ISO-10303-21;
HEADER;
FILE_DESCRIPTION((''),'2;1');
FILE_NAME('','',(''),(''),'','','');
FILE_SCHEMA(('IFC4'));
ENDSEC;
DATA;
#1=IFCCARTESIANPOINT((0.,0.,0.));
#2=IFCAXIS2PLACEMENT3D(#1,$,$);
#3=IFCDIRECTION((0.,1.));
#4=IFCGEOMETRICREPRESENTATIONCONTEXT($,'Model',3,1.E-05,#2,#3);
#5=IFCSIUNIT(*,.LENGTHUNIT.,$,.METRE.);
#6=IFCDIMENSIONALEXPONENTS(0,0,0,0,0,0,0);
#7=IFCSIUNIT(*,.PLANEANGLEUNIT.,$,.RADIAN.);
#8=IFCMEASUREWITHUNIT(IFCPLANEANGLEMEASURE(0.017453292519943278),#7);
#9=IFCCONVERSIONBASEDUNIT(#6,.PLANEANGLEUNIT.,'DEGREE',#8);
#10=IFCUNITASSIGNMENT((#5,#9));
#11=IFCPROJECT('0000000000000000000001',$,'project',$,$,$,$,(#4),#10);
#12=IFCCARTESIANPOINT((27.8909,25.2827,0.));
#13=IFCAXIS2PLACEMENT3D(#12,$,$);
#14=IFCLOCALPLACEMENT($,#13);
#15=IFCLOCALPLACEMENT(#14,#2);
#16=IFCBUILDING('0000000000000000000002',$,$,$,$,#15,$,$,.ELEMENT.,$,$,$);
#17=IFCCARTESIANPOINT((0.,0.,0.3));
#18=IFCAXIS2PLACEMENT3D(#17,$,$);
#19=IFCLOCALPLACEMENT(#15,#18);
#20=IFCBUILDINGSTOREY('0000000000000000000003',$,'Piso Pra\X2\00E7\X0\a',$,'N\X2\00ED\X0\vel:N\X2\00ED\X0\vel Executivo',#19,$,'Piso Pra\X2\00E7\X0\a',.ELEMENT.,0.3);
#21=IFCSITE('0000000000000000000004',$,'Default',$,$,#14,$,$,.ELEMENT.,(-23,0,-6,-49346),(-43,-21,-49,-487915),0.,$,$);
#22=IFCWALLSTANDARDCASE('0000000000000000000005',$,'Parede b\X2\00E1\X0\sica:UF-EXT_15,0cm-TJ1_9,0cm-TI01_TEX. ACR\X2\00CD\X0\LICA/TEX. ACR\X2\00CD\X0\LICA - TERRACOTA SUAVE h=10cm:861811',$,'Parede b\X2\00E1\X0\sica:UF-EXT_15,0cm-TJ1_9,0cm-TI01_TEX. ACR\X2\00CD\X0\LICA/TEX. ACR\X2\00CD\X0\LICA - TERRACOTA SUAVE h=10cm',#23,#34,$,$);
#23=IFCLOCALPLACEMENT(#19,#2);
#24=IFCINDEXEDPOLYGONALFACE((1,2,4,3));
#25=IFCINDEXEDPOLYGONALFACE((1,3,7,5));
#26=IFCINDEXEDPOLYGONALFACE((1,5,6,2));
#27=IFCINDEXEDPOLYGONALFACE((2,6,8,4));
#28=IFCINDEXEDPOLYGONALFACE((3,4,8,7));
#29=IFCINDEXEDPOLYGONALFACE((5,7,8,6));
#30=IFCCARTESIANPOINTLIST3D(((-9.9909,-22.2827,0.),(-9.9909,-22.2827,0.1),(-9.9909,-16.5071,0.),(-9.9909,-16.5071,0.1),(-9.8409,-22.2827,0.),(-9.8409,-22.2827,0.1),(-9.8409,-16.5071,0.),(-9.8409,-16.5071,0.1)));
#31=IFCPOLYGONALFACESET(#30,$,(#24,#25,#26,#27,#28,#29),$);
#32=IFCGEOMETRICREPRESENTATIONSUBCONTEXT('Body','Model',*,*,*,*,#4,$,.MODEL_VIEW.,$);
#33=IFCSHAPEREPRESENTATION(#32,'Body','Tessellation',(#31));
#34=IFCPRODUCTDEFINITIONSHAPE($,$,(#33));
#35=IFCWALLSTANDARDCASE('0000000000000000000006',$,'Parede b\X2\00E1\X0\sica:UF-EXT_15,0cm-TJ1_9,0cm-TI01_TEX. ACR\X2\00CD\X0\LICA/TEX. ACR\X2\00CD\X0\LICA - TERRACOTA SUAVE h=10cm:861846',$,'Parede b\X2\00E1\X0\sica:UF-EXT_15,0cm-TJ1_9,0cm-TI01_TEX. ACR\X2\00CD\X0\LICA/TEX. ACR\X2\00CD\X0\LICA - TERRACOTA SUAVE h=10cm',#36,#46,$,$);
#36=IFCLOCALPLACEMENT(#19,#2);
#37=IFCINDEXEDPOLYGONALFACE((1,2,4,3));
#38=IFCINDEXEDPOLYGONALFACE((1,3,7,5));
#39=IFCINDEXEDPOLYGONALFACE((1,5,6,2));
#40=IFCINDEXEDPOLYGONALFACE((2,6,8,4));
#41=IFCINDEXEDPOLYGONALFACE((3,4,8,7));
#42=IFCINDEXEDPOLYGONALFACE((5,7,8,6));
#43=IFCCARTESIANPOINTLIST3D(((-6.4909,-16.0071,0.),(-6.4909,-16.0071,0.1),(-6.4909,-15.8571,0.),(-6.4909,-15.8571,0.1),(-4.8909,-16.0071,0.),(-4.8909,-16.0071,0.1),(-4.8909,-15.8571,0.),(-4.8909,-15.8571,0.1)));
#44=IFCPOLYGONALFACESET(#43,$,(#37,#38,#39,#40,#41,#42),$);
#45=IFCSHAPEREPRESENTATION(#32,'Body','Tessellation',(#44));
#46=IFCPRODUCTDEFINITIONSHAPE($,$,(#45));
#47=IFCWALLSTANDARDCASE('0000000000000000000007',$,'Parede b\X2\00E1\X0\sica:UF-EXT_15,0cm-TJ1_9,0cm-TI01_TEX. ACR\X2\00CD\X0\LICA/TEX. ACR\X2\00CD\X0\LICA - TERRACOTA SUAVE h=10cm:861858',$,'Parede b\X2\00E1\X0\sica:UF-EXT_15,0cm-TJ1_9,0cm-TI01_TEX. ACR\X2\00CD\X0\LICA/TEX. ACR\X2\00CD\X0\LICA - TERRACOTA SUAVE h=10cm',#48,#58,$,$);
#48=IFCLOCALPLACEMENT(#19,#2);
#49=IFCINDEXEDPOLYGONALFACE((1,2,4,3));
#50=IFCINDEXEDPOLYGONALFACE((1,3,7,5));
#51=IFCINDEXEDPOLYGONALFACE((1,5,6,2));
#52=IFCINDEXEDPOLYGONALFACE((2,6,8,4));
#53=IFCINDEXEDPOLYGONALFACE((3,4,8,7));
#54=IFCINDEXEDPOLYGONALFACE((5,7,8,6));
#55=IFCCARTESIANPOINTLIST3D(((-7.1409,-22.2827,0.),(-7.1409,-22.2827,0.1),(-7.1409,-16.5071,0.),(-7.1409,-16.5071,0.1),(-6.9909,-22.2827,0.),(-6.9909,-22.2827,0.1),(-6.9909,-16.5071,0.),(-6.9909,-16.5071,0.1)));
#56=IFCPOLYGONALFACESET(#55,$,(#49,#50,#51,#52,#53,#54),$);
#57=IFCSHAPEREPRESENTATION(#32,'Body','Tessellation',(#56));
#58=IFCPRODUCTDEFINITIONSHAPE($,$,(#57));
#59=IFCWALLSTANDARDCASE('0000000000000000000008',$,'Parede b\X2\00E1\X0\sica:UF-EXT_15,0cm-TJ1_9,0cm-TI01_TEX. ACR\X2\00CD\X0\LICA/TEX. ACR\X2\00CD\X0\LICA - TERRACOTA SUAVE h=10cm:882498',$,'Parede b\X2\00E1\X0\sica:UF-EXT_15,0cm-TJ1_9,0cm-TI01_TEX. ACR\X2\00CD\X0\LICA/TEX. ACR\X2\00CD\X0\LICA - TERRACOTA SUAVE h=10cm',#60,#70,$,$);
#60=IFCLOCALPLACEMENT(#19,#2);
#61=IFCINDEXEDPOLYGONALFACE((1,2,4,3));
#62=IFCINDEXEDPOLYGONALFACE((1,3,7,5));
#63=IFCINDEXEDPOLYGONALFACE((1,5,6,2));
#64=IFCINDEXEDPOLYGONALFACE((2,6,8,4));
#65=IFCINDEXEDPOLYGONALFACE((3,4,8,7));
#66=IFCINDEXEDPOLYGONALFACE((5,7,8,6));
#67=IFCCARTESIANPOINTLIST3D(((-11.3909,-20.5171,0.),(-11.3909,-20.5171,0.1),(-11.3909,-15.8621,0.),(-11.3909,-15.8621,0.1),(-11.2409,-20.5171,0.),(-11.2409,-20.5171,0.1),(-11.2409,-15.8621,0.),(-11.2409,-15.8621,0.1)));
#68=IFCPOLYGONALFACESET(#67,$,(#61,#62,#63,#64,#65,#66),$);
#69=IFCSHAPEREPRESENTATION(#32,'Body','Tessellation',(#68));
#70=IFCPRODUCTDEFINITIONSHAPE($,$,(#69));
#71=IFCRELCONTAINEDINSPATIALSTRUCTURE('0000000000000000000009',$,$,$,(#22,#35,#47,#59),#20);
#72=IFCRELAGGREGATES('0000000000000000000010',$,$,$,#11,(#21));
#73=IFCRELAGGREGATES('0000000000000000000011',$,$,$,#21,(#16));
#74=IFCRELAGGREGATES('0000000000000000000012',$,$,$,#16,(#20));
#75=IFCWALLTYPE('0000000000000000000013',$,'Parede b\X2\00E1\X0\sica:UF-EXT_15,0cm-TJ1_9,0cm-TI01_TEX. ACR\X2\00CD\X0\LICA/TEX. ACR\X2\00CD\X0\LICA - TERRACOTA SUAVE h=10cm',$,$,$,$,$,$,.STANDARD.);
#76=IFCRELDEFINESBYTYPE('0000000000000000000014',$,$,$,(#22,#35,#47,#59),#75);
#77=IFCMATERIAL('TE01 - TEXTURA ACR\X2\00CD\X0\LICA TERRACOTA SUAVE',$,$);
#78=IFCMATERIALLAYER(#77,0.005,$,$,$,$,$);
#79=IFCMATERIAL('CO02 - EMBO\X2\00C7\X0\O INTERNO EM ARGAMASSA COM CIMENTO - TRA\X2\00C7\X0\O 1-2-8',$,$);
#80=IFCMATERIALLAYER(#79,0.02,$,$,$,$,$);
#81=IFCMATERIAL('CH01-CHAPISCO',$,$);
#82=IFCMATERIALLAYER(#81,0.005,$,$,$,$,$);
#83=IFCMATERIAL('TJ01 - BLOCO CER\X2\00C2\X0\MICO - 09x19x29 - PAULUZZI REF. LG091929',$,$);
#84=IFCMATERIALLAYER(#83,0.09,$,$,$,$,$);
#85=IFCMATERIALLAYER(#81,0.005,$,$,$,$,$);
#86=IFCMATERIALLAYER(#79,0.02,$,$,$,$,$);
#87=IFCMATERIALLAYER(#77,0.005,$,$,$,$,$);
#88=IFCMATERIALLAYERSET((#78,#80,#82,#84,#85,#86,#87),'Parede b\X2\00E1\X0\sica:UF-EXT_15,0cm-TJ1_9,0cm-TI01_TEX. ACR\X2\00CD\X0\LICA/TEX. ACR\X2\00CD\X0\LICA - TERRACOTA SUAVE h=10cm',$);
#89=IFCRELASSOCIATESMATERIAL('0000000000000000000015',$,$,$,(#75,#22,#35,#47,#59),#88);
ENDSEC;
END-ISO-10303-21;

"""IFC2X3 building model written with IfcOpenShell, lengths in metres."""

from ifc_helpers import new_model, entity, si_unit, converted_unit, direction, frame, frame_2d, origin, place, context, subcontext, project, spatial, rectangle, extrude, material, layer, layer_set, layer_usage, type_object, element, save


model = new_model("IFC2X3")

# Units and contexts
model_context = context("Model", 3, precision=1e-05, world=origin(), true_north=direction((0.0, 1.0)))
body_context = subcontext(model_context, "Body", "Model", "MODEL_VIEW")
ifc_project = project(units=[si_unit("LENGTHUNIT", "METRE"), converted_unit("PLANEANGLEUNIT", "DEGREE", entity("IfcPlaneAngleMeasure", 0.017453292519943278), si_unit("PLANEANGLEUNIT", "RADIAN"), dimensions=[0, 0, 0, 0, 0, 0, 0])], contexts=[model_context])

# Site, building, storey
site_placement = place(None, frame((27.8909, 25.2827, 0.0)))
site = spatial("IfcSite", under=ifc_project, at=site_placement, Name="Default", CompositionType="ELEMENT", RefLatitude=(-23, 0, -6, -49346), RefLongitude=(-43, -21, -49, -487915), RefElevation=0.0)
building_placement = place(site_placement, origin())
building = spatial("IfcBuilding", under=site, at=building_placement, CompositionType="ELEMENT")
storey_placement = place(building_placement, frame((0.0, 0.0, 0.3)))
storey = spatial("IfcBuildingStorey", under=building, at=storey_placement, Name="Piso Praça", ObjectType="Nível:Nível Executivo", LongName="Piso Praça", CompositionType="ELEMENT", Elevation=0.3)

# Walls
ifc_material_1 = material(Name="CO02 - EMBOÇO INTERNO EM ARGAMASSA COM CIMENTO - TRAÇO 1-2-8")
ifc_material_2 = material(Name="CH01-CHAPISCO")
ifc_material_3 = material(Name="TJ01 - BLOCO CERÂMICO - 09x19x29 - PAULUZZI REF. LG091929")
ifc_material_4 = material(Name="TE01 - TEXTURA ACRÍLICA TERRACOTA SUAVE")
ifc_layer_1 = layer(ifc_material_4, 0.005)
ifc_layer_2 = layer(ifc_material_1, 0.02)
ifc_layer_3 = layer(ifc_material_2, 0.005)
ifc_layer_4 = layer(ifc_material_3, 0.09)
ifc_layer_5 = layer(ifc_material_2, 0.005)
ifc_layer_6 = layer(ifc_material_1, 0.02)
ifc_layer_7 = layer(ifc_material_4, 0.005)
ifc_layer_set_1 = layer_set([ifc_layer_1, ifc_layer_2, ifc_layer_3, ifc_layer_4, ifc_layer_5, ifc_layer_6, ifc_layer_7], Name="Parede básica:UF-EXT_15,0cm-TJ1_9,0cm-TI01_TEX. ACRÍLICA/TEX. ACRÍLICA - TERRACOTA SUAVE h=10cm")
ifc_layer_usage_1 = layer_usage(ifc_layer_set_1, "AXIS2", "NEGATIVE", 0.075)
wall_type_1 = type_object("IfcWallType", Name="Parede básica:UF-EXT_15,0cm-TJ1_9,0cm-TI01_TEX. ACRÍLICA/TEX. ACRÍLICA - TERRACOTA SUAVE h=10cm", PredefinedType="STANDARD", material=ifc_layer_set_1)
wall_1_placement = place(storey_placement, frame((-9.9159, -22.2827, 0.0), z_axis=(0.0, 0.0, 1.0), x_axis=(0.0, 1.0, 0.0)))
element("IfcWallStandardCase", 1, at=wall_1_placement, inside=storey, type_object=wall_type_1, material=ifc_layer_usage_1, Name="Parede básica:UF-EXT_15,0cm-TJ1_9,0cm-TI01_TEX. ACRÍLICA/TEX. ACRÍLICA - TERRACOTA SUAVE h=10cm:861811", ObjectType="Parede básica:UF-EXT_15,0cm-TJ1_9,0cm-TI01_TEX. ACRÍLICA/TEX. ACRÍLICA - TERRACOTA SUAVE h=10cm", context=body_context, shape_type="SweptSolid", body=[
    extrude(rectangle(XDim=5.7756, YDim=0.15, at=frame_2d((2.8878, 0.0), x_axis=(-1.0, 0.0))), origin(), (0.0, 0.0, 1.0), 0.1),
])
wall_2_placement = place(storey_placement, frame((-6.4909, -15.9321, 0.0)))
element("IfcWallStandardCase", 2, at=wall_2_placement, inside=storey, type_object=wall_type_1, material=ifc_layer_usage_1, Name="Parede básica:UF-EXT_15,0cm-TJ1_9,0cm-TI01_TEX. ACRÍLICA/TEX. ACRÍLICA - TERRACOTA SUAVE h=10cm:861846", ObjectType="Parede básica:UF-EXT_15,0cm-TJ1_9,0cm-TI01_TEX. ACRÍLICA/TEX. ACRÍLICA - TERRACOTA SUAVE h=10cm", context=body_context, shape_type="SweptSolid", body=[
    extrude(rectangle(XDim=1.6, YDim=0.15, at=frame_2d((0.8, 0.0), x_axis=(-1.0, 0.0))), origin(), (0.0, 0.0, 1.0), 0.1),
])
wall_3_placement = place(storey_placement, frame((-7.0659, -22.2827, 0.0), z_axis=(0.0, 0.0, 1.0), x_axis=(0.0, 1.0, 0.0)))
element("IfcWallStandardCase", 3, at=wall_3_placement, inside=storey, type_object=wall_type_1, material=ifc_layer_usage_1, Name="Parede básica:UF-EXT_15,0cm-TJ1_9,0cm-TI01_TEX. ACRÍLICA/TEX. ACRÍLICA - TERRACOTA SUAVE h=10cm:861858", ObjectType="Parede básica:UF-EXT_15,0cm-TJ1_9,0cm-TI01_TEX. ACRÍLICA/TEX. ACRÍLICA - TERRACOTA SUAVE h=10cm", context=body_context, shape_type="SweptSolid", body=[
    extrude(rectangle(XDim=5.7756, YDim=0.15, at=frame_2d((2.8878, 0.0), x_axis=(-1.0, 0.0))), origin(), (0.0, 0.0, 1.0), 0.1),
])
wall_4_placement = place(storey_placement, frame((-11.3159, -15.8621, 0.0), z_axis=(0.0, 0.0, 1.0), x_axis=(0.0, -1.0, 0.0)))
element("IfcWallStandardCase", 4, at=wall_4_placement, inside=storey, type_object=wall_type_1, material=ifc_layer_usage_1, Name="Parede básica:UF-EXT_15,0cm-TJ1_9,0cm-TI01_TEX. ACRÍLICA/TEX. ACRÍLICA - TERRACOTA SUAVE h=10cm:882498", ObjectType="Parede básica:UF-EXT_15,0cm-TJ1_9,0cm-TI01_TEX. ACRÍLICA/TEX. ACRÍLICA - TERRACOTA SUAVE h=10cm", context=body_context, shape_type="SweptSolid", body=[
    extrude(rectangle(XDim=4.655, YDim=0.15, at=frame_2d((2.3275, 0.0), x_axis=(-1.0, 0.0))), origin(), (0.0, 0.0, 1.0), 0.1),
])

save(model, "model.ifc")
